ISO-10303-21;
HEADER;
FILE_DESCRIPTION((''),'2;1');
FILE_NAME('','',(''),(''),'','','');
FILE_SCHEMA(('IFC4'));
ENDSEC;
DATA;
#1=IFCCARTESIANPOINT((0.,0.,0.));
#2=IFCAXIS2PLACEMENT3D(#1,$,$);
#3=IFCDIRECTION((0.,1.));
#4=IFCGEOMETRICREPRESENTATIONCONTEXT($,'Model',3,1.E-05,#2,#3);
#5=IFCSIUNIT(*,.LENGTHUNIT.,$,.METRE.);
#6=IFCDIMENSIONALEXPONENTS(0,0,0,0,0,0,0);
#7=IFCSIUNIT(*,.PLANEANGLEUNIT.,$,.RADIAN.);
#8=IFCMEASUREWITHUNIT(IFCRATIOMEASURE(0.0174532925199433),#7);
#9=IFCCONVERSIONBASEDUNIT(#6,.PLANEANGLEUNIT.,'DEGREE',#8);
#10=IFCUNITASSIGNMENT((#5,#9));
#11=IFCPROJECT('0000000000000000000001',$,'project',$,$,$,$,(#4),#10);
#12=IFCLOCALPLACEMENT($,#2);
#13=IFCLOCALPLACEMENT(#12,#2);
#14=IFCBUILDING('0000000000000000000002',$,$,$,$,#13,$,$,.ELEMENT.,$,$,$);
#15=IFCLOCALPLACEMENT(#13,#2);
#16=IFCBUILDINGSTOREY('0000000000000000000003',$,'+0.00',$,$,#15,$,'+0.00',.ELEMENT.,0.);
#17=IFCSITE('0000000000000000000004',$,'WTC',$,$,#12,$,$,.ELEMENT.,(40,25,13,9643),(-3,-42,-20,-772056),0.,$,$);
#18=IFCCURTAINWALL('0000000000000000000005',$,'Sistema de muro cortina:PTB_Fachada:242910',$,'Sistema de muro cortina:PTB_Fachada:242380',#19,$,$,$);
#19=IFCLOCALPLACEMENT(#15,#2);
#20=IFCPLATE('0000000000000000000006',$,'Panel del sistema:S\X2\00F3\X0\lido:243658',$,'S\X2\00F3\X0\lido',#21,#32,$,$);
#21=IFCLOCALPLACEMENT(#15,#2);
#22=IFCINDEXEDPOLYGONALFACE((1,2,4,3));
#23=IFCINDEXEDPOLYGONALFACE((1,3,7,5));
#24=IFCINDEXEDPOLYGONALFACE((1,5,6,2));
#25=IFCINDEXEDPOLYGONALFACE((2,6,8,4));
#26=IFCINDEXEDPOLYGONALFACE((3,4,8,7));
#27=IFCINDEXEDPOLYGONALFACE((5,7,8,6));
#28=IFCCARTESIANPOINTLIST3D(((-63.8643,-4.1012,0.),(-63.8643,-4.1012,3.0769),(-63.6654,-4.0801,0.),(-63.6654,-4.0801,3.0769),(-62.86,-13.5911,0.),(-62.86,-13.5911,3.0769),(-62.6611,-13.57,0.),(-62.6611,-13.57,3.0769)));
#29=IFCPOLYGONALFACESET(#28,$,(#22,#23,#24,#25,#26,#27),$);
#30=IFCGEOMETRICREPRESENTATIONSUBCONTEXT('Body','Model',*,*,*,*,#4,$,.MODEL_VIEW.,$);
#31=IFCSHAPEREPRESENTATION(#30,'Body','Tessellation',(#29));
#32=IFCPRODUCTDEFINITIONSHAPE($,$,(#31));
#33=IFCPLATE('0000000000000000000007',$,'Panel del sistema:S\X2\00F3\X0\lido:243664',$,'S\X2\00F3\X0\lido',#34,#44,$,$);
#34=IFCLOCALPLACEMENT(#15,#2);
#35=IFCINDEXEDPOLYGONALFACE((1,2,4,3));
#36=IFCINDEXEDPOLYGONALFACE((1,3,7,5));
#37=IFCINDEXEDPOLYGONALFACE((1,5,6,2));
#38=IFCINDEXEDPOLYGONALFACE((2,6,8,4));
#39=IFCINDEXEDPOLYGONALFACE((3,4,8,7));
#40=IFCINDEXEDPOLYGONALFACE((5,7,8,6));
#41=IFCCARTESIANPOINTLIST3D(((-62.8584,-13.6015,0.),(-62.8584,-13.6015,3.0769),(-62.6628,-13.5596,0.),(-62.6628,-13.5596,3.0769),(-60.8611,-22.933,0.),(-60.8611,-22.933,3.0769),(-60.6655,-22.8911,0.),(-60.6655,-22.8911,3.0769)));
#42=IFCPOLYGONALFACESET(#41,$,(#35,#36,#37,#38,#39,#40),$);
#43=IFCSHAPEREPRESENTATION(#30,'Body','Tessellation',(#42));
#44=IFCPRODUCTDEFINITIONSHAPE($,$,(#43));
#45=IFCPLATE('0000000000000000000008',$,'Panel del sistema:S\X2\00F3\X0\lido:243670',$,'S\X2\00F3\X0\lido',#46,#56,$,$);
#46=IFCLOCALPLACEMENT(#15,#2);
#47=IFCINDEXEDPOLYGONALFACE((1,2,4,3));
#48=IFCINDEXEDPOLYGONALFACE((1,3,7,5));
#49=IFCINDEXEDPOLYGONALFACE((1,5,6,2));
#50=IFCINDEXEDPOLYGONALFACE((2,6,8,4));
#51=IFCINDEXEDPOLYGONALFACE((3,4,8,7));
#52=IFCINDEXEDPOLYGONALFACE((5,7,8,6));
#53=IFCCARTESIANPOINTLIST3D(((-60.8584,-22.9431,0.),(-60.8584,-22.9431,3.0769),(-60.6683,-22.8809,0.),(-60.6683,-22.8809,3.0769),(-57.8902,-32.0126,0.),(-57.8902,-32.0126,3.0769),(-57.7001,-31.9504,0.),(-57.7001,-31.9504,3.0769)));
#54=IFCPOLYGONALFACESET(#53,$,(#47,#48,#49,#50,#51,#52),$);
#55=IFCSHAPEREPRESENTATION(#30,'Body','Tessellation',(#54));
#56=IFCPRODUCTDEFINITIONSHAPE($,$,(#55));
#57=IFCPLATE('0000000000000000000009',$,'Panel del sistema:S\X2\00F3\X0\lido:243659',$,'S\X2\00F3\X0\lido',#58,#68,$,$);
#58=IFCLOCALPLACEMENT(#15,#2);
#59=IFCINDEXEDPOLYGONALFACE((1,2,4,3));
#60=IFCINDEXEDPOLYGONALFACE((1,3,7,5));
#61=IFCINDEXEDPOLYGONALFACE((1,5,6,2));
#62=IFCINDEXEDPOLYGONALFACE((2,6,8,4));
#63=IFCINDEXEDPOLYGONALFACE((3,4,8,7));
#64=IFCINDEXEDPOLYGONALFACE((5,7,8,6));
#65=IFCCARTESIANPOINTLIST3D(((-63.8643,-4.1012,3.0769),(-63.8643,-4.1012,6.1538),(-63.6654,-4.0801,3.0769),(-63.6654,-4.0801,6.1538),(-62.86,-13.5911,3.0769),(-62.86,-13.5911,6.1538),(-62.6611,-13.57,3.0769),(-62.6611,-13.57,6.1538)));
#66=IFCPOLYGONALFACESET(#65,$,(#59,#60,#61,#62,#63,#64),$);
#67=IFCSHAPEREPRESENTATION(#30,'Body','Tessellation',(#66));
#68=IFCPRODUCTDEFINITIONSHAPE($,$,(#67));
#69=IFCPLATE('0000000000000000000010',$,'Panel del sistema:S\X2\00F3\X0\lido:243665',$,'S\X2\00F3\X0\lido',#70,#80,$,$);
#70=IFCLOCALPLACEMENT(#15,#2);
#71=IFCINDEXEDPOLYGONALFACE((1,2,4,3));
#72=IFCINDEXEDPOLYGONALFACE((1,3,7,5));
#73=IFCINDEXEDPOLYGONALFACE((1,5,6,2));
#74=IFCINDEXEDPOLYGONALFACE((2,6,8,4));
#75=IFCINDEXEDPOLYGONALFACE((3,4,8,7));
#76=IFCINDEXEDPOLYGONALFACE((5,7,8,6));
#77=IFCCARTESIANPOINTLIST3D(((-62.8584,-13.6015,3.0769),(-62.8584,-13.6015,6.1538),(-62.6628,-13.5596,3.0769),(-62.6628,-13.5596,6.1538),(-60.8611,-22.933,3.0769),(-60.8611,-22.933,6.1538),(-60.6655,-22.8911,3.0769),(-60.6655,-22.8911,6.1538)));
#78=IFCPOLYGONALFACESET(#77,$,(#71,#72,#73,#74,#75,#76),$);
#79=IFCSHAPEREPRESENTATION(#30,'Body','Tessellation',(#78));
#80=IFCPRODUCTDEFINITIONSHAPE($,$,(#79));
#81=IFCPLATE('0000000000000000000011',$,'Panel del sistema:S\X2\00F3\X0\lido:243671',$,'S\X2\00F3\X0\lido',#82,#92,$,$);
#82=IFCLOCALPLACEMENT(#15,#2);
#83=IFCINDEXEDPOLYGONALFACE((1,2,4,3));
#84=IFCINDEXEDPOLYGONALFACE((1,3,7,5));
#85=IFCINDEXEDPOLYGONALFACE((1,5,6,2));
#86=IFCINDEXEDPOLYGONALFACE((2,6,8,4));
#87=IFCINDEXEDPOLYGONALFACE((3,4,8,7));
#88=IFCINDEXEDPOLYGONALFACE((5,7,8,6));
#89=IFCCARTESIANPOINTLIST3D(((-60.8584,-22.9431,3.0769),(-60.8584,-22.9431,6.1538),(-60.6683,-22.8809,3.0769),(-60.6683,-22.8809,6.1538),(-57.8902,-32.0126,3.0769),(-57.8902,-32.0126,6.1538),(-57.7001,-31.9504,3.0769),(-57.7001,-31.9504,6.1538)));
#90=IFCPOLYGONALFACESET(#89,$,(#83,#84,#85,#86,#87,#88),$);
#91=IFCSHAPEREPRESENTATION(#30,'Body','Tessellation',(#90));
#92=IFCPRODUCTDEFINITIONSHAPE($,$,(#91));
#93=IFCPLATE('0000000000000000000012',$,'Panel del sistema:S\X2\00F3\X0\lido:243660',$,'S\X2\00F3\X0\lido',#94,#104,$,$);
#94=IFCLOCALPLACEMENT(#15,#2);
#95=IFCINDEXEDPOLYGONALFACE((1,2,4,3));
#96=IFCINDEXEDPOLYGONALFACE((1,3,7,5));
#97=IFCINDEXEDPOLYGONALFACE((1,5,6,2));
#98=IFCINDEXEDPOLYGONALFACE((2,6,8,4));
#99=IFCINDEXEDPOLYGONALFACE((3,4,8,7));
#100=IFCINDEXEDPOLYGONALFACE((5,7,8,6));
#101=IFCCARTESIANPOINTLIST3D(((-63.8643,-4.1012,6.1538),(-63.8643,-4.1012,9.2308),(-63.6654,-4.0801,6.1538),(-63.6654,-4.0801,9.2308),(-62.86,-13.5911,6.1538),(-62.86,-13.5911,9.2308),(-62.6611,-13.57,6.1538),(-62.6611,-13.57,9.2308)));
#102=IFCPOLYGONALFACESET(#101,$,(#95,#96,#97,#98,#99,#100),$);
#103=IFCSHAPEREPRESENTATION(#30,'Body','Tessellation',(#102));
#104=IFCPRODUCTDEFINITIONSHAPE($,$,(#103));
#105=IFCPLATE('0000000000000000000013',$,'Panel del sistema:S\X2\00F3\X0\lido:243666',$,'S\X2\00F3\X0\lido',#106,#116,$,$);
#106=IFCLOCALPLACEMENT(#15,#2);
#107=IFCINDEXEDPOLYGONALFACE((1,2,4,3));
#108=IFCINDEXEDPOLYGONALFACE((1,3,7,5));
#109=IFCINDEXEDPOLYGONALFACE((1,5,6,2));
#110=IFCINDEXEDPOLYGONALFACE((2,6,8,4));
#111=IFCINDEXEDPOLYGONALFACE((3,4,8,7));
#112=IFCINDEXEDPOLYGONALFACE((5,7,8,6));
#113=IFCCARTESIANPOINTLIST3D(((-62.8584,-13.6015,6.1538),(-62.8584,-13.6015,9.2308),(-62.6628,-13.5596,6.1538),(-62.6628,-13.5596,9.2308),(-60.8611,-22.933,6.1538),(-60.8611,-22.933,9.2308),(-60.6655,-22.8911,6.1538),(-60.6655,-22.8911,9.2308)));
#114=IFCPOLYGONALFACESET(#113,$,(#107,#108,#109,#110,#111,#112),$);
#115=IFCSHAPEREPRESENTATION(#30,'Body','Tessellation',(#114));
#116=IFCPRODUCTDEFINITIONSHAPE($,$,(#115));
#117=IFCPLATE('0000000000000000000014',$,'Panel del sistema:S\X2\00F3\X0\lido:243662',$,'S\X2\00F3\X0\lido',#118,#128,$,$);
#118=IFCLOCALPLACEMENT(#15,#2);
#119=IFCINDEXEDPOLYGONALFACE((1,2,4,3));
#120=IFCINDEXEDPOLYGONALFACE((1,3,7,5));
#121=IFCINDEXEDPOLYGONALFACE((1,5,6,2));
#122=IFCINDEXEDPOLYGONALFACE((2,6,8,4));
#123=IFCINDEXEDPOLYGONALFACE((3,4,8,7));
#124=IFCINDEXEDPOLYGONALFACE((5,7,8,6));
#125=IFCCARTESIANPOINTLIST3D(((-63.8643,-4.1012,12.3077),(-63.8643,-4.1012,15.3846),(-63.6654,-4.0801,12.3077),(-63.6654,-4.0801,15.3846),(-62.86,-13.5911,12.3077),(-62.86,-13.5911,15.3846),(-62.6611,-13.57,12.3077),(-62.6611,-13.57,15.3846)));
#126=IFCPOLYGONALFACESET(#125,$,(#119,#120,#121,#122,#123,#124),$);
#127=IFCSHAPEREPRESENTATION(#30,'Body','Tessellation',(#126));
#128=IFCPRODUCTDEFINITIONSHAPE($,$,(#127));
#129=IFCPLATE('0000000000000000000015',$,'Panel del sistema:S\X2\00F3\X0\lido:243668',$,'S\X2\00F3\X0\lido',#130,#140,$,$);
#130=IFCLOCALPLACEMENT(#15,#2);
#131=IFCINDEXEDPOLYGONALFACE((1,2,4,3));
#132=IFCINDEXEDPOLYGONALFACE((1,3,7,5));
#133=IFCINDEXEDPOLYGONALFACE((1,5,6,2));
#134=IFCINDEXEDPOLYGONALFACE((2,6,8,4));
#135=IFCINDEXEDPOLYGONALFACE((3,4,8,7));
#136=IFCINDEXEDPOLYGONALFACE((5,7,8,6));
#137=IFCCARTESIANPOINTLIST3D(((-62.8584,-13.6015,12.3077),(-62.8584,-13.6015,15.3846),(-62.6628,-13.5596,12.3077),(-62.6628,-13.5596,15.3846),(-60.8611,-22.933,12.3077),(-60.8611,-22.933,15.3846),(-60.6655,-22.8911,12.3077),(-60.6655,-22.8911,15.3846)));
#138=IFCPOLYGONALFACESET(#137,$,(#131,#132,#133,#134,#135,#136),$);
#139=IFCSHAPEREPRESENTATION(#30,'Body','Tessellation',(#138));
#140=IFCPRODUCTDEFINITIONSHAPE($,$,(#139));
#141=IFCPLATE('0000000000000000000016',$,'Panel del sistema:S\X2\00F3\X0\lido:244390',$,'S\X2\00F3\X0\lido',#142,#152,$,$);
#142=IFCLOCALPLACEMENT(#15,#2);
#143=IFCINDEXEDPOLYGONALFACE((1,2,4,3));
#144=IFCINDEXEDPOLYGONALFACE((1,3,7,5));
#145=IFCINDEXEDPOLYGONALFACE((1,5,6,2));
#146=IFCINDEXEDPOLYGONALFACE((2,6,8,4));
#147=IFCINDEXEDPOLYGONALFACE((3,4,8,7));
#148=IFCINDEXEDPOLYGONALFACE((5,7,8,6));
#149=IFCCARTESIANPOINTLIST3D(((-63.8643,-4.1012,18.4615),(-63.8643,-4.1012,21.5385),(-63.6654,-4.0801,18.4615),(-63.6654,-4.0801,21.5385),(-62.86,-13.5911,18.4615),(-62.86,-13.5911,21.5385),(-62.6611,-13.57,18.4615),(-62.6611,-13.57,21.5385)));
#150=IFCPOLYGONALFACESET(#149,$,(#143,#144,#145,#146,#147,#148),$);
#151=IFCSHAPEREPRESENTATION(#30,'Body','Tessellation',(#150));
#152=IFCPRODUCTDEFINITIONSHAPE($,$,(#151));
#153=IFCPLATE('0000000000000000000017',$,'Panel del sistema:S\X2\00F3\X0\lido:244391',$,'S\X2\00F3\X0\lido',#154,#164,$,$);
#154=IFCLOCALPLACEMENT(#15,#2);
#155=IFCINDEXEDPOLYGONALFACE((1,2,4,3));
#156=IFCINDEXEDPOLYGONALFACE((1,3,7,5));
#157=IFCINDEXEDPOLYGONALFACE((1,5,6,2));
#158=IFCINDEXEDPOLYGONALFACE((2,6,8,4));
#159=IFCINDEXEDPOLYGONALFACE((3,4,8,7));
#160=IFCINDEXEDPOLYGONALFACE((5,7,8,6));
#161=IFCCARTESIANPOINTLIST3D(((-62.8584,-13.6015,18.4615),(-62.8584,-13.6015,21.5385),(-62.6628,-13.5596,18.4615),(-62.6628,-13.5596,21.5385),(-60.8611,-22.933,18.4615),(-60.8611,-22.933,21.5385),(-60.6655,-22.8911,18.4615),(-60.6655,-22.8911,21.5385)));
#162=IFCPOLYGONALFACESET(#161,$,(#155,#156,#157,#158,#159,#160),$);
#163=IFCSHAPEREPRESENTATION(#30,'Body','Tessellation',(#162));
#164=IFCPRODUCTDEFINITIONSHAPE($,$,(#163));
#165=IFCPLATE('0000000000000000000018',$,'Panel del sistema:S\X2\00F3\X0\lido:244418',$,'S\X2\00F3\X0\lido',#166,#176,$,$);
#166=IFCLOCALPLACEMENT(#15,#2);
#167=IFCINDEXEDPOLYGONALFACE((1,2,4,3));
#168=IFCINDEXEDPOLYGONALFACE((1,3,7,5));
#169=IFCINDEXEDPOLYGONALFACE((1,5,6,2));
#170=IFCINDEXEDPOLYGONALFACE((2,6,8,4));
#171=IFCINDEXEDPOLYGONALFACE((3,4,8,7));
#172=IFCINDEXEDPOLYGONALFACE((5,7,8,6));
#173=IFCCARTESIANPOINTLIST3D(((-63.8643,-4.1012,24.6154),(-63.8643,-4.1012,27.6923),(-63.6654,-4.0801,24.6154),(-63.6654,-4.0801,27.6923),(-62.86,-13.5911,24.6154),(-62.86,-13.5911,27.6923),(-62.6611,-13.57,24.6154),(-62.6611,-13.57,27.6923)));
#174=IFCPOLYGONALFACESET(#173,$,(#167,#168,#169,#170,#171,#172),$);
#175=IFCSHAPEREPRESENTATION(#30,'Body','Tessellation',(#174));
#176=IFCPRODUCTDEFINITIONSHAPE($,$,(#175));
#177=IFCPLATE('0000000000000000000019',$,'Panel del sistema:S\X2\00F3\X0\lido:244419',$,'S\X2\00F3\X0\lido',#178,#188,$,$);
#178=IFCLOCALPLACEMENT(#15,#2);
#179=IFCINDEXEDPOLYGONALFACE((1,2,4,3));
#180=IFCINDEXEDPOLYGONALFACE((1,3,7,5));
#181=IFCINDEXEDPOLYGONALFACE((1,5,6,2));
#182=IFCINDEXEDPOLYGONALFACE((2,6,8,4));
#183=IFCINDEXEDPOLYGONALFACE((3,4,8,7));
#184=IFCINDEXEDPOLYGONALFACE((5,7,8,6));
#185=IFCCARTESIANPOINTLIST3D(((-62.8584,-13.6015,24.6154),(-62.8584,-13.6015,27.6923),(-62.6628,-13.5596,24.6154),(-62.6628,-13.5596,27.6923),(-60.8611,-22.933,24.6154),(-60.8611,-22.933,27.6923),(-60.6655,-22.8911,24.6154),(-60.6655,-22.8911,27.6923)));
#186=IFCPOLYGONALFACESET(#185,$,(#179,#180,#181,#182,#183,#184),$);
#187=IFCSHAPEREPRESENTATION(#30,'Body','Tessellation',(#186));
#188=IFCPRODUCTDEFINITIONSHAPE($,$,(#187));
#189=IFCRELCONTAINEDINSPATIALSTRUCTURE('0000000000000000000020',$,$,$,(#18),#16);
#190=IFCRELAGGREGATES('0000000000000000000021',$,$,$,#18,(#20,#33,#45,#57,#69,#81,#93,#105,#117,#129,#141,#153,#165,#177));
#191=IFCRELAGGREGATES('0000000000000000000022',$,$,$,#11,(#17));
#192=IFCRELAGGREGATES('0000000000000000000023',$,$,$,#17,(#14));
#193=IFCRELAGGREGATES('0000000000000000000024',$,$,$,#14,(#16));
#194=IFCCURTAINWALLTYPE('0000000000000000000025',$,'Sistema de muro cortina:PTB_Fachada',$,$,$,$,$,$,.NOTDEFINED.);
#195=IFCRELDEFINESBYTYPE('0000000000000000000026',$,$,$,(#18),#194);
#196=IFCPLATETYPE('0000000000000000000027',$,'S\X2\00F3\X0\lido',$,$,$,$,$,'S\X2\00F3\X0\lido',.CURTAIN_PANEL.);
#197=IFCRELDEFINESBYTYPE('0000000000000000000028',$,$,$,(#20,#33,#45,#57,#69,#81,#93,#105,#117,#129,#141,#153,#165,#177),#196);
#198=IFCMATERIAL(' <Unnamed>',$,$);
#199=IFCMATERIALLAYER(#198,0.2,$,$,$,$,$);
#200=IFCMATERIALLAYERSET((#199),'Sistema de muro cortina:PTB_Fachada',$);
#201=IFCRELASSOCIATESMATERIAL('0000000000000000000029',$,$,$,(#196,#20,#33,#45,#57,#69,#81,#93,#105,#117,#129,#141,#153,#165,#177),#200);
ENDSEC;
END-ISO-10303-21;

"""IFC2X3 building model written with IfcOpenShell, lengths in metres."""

from ifc_helpers import new_model, entity, si_unit, converted_unit, direction, frame, frame_2d, origin, place, context, subcontext, project, spatial, rectangle, extrude, source, transform, mapped, material, layer, layer_set, layer_usage, type_object, type_shapes, element, aggregate, save


model = new_model("IFC2X3")

# Units and contexts
model_context = context("Model", 3, precision=1e-05, world=origin(), true_north=direction((0.0, 1.0)))
body_context = subcontext(model_context, "Body", "Model", "MODEL_VIEW")
ifc_project = project(units=[si_unit("LENGTHUNIT", "METRE"), converted_unit("PLANEANGLEUNIT", "DEGREE", entity("IfcRatioMeasure", 0.0174532925199433), si_unit("PLANEANGLEUNIT", "RADIAN"), dimensions=[0, 0, 0, 0, 0, 0, 0])], contexts=[model_context])

# Site, building, storey
site_placement = place(None, origin())
site = spatial("IfcSite", under=ifc_project, at=site_placement, Name="WTC", CompositionType="ELEMENT", RefLatitude=(40, 25, 13, 9643), RefLongitude=(-3, -42, -20, -772056), RefElevation=0.0)
building_placement = place(site_placement, origin())
building = spatial("IfcBuilding", under=site, at=building_placement, CompositionType="ELEMENT")
storey_placement = place(building_placement, origin())
storey = spatial("IfcBuildingStorey", under=building, at=storey_placement, Name="+0.00", LongName="+0.00", CompositionType="ELEMENT", Elevation=0.0)

# Curtain wall, plates
curtain_wall_type = type_object("IfcCurtainWallType", Name="Sistema de muro cortina:PTB_Fachada", PredefinedType="NOTDEFINED")
curtain_wall_placement = place(storey_placement, origin())
curtain_wall = element("IfcCurtainWall", 1, at=curtain_wall_placement, inside=storey, type_object=curtain_wall_type, Name="Sistema de muro cortina:PTB_Fachada:242910", ObjectType="Sistema de muro cortina:PTB_Fachada:242380")
ifc_material_1 = material(Name=" <Unnamed>")
ifc_layer_1 = layer(ifc_material_1, 0.2)
ifc_layer_set_1 = layer_set([ifc_layer_1], Name="Sistema de muro cortina:PTB_Fachada")
ifc_layer_usage_1 = layer_usage(ifc_layer_set_1, "AXIS3", "POSITIVE", 0.0)
plate_type_1 = type_object("IfcPlateType", Name="Sólido", ElementType="Sólido", PredefinedType="CURTAIN_PANEL", material=ifc_layer_set_1)
shared_shape_1 = source(origin(), body_context, "Body", "SweptSolid", [
    extrude(rectangle(XDim=0.2, YDim=9.5428, at=frame_2d((0.0, 0.0), x_axis=(1.0, 0.0))), frame((0.0, 0.0, 0.0), z_axis=(0.0, 0.0, 1.0), x_axis=(0.0, 1.0, 0.0)), (0.0, 0.0, 1.0), 3.0769),
])
type_shapes(plate_type_1, [shared_shape_1])
plate_1_placement = place(curtain_wall_placement, frame((-63.2627, -8.8356, 0.0), z_axis=(0.0, 0.0, 1.0), x_axis=(0.105232, -0.994448, 0.0)))
plate_1 = element("IfcPlate", 2, at=plate_1_placement, type_object=plate_type_1, material=ifc_layer_usage_1, Name="Panel del sistema:Sólido:243658", ObjectType="Sólido", context=body_context, shape_type="MappedRepresentation", body=[
    mapped(shared_shape_1, transform((0.0, 0.0, 0.0), scale=1.0)),
])
ifc_layer_usage_2 = layer_usage(ifc_layer_set_1, "AXIS3", "POSITIVE", 0.0)
plate_2_placement = place(curtain_wall_placement, frame((-61.762, -18.2463, 0.0), z_axis=(0.0, 0.0, 1.0), x_axis=(0.209296, -0.977852, 0.0)))
plate_2 = element("IfcPlate", 3, at=plate_2_placement, type_object=plate_type_1, material=ifc_layer_usage_2, Name="Panel del sistema:Sólido:243664", ObjectType="Sólido", context=body_context, shape_type="MappedRepresentation", body=[
    mapped(shared_shape_1, transform((0.0, 0.0, 0.0), scale=1.0)),
])
ifc_layer_usage_3 = layer_usage(ifc_layer_set_1, "AXIS3", "POSITIVE", 0.0)
plate_3_placement = place(curtain_wall_placement, frame((-59.2792, -27.4468, 0.0), z_axis=(0.0, 0.0, 1.0), x_axis=(0.311036, -0.950398, 0.0)))
plate_3 = element("IfcPlate", 4, at=plate_3_placement, type_object=plate_type_1, material=ifc_layer_usage_3, Name="Panel del sistema:Sólido:243670", ObjectType="Sólido", context=body_context, shape_type="MappedRepresentation", body=[
    mapped(shared_shape_1, transform((0.0, 0.0, 0.0), scale=1.0)),
])
ifc_layer_usage_4 = layer_usage(ifc_layer_set_1, "AXIS3", "POSITIVE", 0.0)
plate_4_placement = place(curtain_wall_placement, frame((-63.2627, -8.8356, 3.0769), z_axis=(0.0, 0.0, 1.0), x_axis=(0.105232, -0.994448, 0.0)))
plate_4 = element("IfcPlate", 5, at=plate_4_placement, type_object=plate_type_1, material=ifc_layer_usage_4, Name="Panel del sistema:Sólido:243659", ObjectType="Sólido", context=body_context, shape_type="MappedRepresentation", body=[
    mapped(shared_shape_1, transform((0.0, 0.0, 0.0), scale=1.0)),
])
ifc_layer_usage_5 = layer_usage(ifc_layer_set_1, "AXIS3", "POSITIVE", 0.0)
plate_5_placement = place(curtain_wall_placement, frame((-61.762, -18.2463, 3.0769), z_axis=(0.0, 0.0, 1.0), x_axis=(0.209296, -0.977852, 0.0)))
plate_5 = element("IfcPlate", 6, at=plate_5_placement, type_object=plate_type_1, material=ifc_layer_usage_5, Name="Panel del sistema:Sólido:243665", ObjectType="Sólido", context=body_context, shape_type="MappedRepresentation", body=[
    mapped(shared_shape_1, transform((0.0, 0.0, 0.0), scale=1.0)),
])
ifc_layer_usage_6 = layer_usage(ifc_layer_set_1, "AXIS3", "POSITIVE", 0.0)
plate_6_placement = place(curtain_wall_placement, frame((-59.2792, -27.4468, 3.0769), z_axis=(0.0, 0.0, 1.0), x_axis=(0.311036, -0.950398, 0.0)))
plate_6 = element("IfcPlate", 7, at=plate_6_placement, type_object=plate_type_1, material=ifc_layer_usage_6, Name="Panel del sistema:Sólido:243671", ObjectType="Sólido", context=body_context, shape_type="MappedRepresentation", body=[
    mapped(shared_shape_1, transform((0.0, 0.0, 0.0), scale=1.0)),
])
ifc_layer_usage_7 = layer_usage(ifc_layer_set_1, "AXIS3", "POSITIVE", 0.0)
plate_7_placement = place(curtain_wall_placement, frame((-63.2627, -8.8356, 6.1538), z_axis=(0.0, 0.0, 1.0), x_axis=(0.105232, -0.994448, 0.0)))
plate_7 = element("IfcPlate", 8, at=plate_7_placement, type_object=plate_type_1, material=ifc_layer_usage_7, Name="Panel del sistema:Sólido:243660", ObjectType="Sólido", context=body_context, shape_type="MappedRepresentation", body=[
    mapped(shared_shape_1, transform((0.0, 0.0, 0.0), scale=1.0)),
])
ifc_layer_usage_8 = layer_usage(ifc_layer_set_1, "AXIS3", "POSITIVE", 0.0)
plate_8_placement = place(curtain_wall_placement, frame((-61.762, -18.2463, 6.1538), z_axis=(0.0, 0.0, 1.0), x_axis=(0.209296, -0.977852, 0.0)))
plate_8 = element("IfcPlate", 9, at=plate_8_placement, type_object=plate_type_1, material=ifc_layer_usage_8, Name="Panel del sistema:Sólido:243666", ObjectType="Sólido", context=body_context, shape_type="MappedRepresentation", body=[
    mapped(shared_shape_1, transform((0.0, 0.0, 0.0), scale=1.0)),
])
ifc_layer_usage_9 = layer_usage(ifc_layer_set_1, "AXIS3", "POSITIVE", 0.0)
plate_9_placement = place(curtain_wall_placement, frame((-63.2627, -8.8356, 12.3077), z_axis=(0.0, 0.0, 1.0), x_axis=(0.105232, -0.994448, 0.0)))
plate_9 = element("IfcPlate", 10, at=plate_9_placement, type_object=plate_type_1, material=ifc_layer_usage_9, Name="Panel del sistema:Sólido:243662", ObjectType="Sólido", context=body_context, shape_type="MappedRepresentation", body=[
    mapped(shared_shape_1, transform((0.0, 0.0, 0.0), scale=1.0)),
])
ifc_layer_usage_10 = layer_usage(ifc_layer_set_1, "AXIS3", "POSITIVE", 0.0)
plate_10_placement = place(curtain_wall_placement, frame((-61.762, -18.2463, 12.3077), z_axis=(0.0, 0.0, 1.0), x_axis=(0.209296, -0.977852, 0.0)))
plate_10 = element("IfcPlate", 11, at=plate_10_placement, type_object=plate_type_1, material=ifc_layer_usage_10, Name="Panel del sistema:Sólido:243668", ObjectType="Sólido", context=body_context, shape_type="MappedRepresentation", body=[
    mapped(shared_shape_1, transform((0.0, 0.0, 0.0), scale=1.0)),
])
ifc_layer_usage_11 = layer_usage(ifc_layer_set_1, "AXIS3", "POSITIVE", 0.0)
plate_11_placement = place(curtain_wall_placement, frame((-63.2627, -8.8356, 18.4615), z_axis=(0.0, 0.0, 1.0), x_axis=(0.105232, -0.994448, 0.0)))
plate_11 = element("IfcPlate", 12, at=plate_11_placement, type_object=plate_type_1, material=ifc_layer_usage_11, Name="Panel del sistema:Sólido:244390", ObjectType="Sólido", context=body_context, shape_type="MappedRepresentation", body=[
    mapped(shared_shape_1, transform((0.0, 0.0, 0.0), scale=1.0)),
])
ifc_layer_usage_12 = layer_usage(ifc_layer_set_1, "AXIS3", "POSITIVE", 0.0)
plate_12_placement = place(curtain_wall_placement, frame((-61.762, -18.2463, 18.4615), z_axis=(0.0, 0.0, 1.0), x_axis=(0.209296, -0.977852, 0.0)))
plate_12 = element("IfcPlate", 13, at=plate_12_placement, type_object=plate_type_1, material=ifc_layer_usage_12, Name="Panel del sistema:Sólido:244391", ObjectType="Sólido", context=body_context, shape_type="MappedRepresentation", body=[
    mapped(shared_shape_1, transform((0.0, 0.0, 0.0), scale=1.0)),
])
ifc_layer_usage_13 = layer_usage(ifc_layer_set_1, "AXIS3", "POSITIVE", 0.0)
plate_13_placement = place(curtain_wall_placement, frame((-63.2627, -8.8356, 24.6154), z_axis=(0.0, 0.0, 1.0), x_axis=(0.105232, -0.994448, 0.0)))
plate_13 = element("IfcPlate", 14, at=plate_13_placement, type_object=plate_type_1, material=ifc_layer_usage_13, Name="Panel del sistema:Sólido:244418", ObjectType="Sólido", context=body_context, shape_type="MappedRepresentation", body=[
    mapped(shared_shape_1, transform((0.0, 0.0, 0.0), scale=1.0)),
])
ifc_layer_usage_14 = layer_usage(ifc_layer_set_1, "AXIS3", "POSITIVE", 0.0)
plate_14_placement = place(curtain_wall_placement, frame((-61.762, -18.2463, 24.6154), z_axis=(0.0, 0.0, 1.0), x_axis=(0.209296, -0.977852, 0.0)))
plate_14 = element("IfcPlate", 15, at=plate_14_placement, type_object=plate_type_1, material=ifc_layer_usage_14, Name="Panel del sistema:Sólido:244419", ObjectType="Sólido", context=body_context, shape_type="MappedRepresentation", body=[
    mapped(shared_shape_1, transform((0.0, 0.0, 0.0), scale=1.0)),
])
aggregate(curtain_wall, [plate_1, plate_2, plate_3, plate_4, plate_5, plate_6, plate_7, plate_8, plate_9, plate_10, plate_11, plate_12, plate_13, plate_14])

save(model, "model.ifc")
